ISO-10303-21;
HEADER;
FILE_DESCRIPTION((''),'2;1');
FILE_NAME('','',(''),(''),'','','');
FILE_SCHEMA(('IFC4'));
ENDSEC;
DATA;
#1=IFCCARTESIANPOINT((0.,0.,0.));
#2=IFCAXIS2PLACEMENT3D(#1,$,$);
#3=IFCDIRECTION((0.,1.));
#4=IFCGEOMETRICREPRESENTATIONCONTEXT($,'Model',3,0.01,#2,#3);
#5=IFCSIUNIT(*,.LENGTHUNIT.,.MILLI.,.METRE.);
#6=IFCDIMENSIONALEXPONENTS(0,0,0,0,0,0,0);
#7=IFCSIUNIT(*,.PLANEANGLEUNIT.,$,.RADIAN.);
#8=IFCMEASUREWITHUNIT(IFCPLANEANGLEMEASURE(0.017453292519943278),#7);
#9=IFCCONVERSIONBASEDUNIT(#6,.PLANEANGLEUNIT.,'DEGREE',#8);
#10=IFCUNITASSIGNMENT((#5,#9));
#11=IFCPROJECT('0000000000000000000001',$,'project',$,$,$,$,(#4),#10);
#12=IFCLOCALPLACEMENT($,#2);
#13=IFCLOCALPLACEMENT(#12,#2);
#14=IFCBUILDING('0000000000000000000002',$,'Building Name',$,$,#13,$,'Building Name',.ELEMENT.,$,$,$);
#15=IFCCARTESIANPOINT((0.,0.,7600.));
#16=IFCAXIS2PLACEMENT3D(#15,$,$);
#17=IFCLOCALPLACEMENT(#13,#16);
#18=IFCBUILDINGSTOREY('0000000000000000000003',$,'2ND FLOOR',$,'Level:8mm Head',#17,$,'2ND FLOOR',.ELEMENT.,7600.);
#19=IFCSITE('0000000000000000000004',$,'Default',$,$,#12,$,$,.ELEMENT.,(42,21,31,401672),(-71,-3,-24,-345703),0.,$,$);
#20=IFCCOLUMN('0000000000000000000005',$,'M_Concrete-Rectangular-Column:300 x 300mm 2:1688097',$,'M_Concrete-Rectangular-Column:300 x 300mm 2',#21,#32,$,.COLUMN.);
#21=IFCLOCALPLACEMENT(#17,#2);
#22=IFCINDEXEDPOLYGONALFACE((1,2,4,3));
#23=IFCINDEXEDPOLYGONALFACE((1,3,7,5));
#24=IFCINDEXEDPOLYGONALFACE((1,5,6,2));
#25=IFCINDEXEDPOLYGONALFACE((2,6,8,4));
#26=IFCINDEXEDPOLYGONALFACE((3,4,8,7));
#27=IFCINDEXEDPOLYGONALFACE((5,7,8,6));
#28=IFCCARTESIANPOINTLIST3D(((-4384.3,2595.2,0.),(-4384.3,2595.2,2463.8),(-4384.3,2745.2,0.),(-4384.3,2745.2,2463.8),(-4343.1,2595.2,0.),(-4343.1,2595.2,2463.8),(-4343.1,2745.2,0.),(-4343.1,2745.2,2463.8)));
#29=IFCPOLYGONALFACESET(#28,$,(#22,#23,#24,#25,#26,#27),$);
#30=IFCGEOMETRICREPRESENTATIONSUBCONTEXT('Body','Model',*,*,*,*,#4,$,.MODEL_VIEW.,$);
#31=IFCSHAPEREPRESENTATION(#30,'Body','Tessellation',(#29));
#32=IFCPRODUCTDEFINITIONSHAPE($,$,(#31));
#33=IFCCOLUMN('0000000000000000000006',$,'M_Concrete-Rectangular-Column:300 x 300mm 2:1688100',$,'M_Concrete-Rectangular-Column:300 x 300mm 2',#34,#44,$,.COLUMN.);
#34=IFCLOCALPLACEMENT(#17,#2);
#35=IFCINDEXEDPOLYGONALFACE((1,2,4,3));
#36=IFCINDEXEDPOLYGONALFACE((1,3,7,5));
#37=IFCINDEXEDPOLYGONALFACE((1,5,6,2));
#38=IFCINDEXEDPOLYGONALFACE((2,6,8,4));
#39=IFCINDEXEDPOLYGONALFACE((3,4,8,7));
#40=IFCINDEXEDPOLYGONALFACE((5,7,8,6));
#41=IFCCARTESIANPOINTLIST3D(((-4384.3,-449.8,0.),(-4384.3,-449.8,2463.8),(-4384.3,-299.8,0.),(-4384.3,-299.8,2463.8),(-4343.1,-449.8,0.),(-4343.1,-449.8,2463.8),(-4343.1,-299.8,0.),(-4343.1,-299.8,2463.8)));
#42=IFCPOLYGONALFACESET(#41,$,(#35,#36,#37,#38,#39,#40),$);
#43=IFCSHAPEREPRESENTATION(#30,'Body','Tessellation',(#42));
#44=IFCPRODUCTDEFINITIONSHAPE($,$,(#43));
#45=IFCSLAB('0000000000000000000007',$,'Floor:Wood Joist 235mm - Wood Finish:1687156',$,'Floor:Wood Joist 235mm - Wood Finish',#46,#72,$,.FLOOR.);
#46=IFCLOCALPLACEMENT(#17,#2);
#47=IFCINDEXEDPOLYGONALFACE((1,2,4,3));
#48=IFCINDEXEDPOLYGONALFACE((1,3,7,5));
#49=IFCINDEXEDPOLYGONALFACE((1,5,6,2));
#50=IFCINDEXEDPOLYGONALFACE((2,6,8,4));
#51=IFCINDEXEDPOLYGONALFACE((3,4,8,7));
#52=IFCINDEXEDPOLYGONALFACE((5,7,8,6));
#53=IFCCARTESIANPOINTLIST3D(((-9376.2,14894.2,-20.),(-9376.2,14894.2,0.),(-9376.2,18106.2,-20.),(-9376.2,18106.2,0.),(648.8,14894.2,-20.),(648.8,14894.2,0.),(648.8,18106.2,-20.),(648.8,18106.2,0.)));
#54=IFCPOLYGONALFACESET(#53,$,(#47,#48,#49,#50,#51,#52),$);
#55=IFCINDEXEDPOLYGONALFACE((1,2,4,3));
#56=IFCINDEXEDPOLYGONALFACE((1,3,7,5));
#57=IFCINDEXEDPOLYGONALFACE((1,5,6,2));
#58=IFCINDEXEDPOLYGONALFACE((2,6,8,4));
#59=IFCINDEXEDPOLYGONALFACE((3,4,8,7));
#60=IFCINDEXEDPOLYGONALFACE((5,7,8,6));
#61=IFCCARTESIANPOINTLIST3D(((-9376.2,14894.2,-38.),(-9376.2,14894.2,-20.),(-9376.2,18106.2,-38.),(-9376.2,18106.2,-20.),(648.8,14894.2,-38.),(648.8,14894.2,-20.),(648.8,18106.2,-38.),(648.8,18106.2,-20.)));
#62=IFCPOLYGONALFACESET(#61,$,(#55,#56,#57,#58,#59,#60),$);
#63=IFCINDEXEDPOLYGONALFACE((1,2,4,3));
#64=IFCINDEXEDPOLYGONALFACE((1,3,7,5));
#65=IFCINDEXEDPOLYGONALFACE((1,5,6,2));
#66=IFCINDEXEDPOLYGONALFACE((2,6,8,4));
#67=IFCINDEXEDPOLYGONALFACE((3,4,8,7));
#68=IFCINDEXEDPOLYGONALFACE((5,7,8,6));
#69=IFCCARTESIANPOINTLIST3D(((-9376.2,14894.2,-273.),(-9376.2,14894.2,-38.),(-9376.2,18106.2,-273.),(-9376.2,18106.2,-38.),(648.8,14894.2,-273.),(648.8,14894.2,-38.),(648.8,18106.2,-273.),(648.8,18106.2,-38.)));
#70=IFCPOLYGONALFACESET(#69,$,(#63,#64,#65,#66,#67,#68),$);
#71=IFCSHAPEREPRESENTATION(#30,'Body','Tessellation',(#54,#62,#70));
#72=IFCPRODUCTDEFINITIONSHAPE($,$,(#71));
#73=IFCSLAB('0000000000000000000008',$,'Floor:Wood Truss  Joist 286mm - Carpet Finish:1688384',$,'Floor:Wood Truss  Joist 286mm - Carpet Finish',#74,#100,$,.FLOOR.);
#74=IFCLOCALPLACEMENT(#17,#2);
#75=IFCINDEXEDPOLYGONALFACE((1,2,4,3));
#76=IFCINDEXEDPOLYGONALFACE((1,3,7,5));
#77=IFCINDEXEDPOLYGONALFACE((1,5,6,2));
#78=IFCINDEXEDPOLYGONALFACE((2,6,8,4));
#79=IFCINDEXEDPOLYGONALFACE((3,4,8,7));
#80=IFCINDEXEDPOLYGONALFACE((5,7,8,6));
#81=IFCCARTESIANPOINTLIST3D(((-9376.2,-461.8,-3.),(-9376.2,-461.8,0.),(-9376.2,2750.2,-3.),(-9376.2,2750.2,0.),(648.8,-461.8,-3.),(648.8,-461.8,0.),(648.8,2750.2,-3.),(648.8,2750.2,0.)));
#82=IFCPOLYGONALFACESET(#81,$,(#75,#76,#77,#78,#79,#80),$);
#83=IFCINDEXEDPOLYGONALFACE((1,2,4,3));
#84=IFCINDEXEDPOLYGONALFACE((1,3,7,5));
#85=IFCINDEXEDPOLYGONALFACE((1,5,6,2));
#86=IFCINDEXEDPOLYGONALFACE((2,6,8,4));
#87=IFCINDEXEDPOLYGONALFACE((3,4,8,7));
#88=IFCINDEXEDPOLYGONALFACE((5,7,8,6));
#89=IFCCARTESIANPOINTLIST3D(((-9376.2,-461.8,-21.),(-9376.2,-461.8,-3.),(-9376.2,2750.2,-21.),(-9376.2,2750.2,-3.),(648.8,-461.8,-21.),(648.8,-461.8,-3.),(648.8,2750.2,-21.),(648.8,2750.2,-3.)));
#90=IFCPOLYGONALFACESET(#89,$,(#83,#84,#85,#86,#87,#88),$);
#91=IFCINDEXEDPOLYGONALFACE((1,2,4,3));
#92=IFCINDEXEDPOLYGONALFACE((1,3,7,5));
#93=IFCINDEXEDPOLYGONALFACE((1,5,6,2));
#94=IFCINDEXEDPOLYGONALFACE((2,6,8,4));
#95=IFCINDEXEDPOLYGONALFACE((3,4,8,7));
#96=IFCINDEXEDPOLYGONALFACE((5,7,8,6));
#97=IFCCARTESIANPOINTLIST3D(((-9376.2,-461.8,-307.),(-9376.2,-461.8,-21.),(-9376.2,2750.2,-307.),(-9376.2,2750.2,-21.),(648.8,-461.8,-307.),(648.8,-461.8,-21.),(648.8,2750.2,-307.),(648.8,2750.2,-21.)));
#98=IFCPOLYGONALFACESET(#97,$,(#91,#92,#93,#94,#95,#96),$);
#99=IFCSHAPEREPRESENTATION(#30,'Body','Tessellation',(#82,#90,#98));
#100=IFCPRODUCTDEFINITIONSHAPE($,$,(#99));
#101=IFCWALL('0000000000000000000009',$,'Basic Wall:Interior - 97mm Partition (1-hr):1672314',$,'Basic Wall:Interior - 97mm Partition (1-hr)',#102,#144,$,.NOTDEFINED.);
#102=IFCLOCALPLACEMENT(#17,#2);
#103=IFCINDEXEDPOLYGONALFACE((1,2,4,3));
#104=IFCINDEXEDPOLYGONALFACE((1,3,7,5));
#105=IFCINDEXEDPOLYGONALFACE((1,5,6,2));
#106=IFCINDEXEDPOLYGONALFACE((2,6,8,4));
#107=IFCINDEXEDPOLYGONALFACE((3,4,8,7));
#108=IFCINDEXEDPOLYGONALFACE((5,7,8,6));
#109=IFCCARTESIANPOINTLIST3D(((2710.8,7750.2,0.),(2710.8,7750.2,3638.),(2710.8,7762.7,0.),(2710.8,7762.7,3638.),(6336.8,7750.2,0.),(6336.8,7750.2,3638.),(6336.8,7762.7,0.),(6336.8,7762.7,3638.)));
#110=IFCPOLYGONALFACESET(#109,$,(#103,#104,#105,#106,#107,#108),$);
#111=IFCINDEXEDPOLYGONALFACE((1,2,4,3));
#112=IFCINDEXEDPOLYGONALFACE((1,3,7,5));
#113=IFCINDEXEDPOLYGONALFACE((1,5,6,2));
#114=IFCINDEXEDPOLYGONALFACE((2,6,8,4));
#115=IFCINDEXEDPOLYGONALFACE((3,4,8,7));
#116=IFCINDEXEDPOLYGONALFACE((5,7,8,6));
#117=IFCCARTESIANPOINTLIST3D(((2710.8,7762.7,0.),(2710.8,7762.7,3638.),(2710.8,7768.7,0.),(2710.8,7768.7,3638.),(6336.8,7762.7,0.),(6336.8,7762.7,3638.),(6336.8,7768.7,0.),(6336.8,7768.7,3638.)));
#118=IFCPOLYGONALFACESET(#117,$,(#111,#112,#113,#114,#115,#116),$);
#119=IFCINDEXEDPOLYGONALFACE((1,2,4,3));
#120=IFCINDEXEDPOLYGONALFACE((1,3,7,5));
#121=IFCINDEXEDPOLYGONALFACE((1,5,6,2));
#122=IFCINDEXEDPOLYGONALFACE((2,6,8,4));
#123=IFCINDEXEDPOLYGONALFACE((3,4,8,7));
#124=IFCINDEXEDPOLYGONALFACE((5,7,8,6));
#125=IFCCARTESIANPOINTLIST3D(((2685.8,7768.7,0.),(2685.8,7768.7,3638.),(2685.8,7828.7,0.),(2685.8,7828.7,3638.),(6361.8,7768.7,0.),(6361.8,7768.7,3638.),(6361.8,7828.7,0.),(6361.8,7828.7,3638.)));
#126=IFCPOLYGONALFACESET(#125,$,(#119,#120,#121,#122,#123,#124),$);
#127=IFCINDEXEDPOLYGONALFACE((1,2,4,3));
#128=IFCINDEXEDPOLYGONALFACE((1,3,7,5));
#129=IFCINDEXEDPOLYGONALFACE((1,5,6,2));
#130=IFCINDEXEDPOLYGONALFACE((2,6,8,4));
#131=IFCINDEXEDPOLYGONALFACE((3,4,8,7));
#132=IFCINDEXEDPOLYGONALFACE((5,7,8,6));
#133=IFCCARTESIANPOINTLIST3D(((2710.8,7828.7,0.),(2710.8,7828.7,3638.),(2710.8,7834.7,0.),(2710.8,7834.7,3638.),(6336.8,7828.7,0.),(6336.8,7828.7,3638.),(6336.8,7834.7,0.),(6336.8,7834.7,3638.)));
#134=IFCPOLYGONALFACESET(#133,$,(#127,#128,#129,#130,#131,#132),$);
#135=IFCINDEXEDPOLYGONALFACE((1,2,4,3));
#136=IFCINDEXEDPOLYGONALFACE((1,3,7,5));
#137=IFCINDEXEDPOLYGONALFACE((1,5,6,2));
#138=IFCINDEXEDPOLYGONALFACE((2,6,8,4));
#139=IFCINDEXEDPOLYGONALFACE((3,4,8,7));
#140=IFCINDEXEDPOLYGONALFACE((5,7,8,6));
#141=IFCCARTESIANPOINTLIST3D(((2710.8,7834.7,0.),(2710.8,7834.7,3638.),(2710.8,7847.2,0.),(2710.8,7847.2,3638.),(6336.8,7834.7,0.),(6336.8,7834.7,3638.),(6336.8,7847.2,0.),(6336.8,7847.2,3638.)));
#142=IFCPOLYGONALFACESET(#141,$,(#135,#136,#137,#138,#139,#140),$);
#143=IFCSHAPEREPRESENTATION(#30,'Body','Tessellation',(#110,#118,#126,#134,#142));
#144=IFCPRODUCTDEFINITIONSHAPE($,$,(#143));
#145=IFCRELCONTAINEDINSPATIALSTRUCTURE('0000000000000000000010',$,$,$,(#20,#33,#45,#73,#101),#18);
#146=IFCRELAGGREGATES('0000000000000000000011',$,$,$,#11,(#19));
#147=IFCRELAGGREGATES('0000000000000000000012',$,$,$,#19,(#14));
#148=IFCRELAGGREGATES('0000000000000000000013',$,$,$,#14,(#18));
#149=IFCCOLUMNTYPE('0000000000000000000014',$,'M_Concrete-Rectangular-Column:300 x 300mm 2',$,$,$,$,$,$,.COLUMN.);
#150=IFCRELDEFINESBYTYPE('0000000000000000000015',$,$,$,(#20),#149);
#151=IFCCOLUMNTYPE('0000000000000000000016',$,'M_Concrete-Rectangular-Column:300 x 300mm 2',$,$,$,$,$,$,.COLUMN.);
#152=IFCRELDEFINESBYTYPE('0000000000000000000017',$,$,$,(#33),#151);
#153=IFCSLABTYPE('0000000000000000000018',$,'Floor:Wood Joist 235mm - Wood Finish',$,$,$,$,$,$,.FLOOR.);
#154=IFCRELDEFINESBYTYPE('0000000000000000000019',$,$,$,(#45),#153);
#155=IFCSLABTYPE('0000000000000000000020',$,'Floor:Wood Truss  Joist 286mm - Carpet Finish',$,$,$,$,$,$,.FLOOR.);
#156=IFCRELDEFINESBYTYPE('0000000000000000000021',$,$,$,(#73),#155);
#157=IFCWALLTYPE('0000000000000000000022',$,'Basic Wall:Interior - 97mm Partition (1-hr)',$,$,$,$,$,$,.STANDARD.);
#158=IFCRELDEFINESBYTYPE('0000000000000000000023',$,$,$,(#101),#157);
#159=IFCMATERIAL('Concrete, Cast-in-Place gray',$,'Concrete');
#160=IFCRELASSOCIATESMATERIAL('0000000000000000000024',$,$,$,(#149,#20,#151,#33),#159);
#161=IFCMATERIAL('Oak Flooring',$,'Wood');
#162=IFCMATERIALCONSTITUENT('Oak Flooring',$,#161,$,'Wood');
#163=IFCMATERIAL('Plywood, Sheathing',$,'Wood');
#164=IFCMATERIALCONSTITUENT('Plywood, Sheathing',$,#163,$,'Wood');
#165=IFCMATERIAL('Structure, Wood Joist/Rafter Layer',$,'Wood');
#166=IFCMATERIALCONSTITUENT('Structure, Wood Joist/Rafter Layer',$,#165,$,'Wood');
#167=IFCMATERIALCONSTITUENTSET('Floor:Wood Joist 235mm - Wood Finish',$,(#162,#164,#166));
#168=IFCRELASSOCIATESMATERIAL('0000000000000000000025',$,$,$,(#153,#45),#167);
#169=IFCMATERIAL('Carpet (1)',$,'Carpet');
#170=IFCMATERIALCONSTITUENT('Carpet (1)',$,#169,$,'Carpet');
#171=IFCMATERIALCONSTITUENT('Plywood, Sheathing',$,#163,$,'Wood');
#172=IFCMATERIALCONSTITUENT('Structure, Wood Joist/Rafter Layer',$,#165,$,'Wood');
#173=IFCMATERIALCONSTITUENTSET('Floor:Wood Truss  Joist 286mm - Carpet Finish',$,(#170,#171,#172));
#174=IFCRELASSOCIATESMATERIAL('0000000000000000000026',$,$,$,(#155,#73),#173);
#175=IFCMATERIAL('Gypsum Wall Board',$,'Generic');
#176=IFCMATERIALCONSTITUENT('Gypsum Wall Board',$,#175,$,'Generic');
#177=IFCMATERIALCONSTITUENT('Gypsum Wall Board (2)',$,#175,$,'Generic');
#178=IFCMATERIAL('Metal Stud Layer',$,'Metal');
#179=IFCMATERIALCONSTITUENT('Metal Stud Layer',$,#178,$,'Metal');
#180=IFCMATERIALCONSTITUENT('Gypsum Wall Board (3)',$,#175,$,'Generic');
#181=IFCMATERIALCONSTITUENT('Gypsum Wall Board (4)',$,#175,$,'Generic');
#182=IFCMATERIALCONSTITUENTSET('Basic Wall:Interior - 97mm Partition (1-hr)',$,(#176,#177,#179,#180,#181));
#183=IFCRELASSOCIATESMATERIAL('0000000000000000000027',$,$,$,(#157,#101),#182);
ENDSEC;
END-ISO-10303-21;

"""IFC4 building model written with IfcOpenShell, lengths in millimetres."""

from ifc_helpers import new_model, entity, si_unit, converted_unit, direction, frame, origin, place, context, subcontext, project, spatial, indexed_curve, outline, extrude, source, transform, mapped, material, constituent, constituent_set, type_object, type_shapes, element, save


model = new_model("IFC4")

# Units and contexts
model_context = context("Model", 3, precision=0.01, world=origin(), true_north=direction((0.0, 1.0)))
body_context = subcontext(model_context, "Body", "Model", "MODEL_VIEW")
ifc_project = project(units=[si_unit("LENGTHUNIT", "METRE", prefix="MILLI"), converted_unit("PLANEANGLEUNIT", "DEGREE", entity("IfcPlaneAngleMeasure", 0.017453292519943278), si_unit("PLANEANGLEUNIT", "RADIAN"), dimensions=[0, 0, 0, 0, 0, 0, 0])], contexts=[model_context])

# Site, building, storey
site_placement = place(None, origin())
site = spatial("IfcSite", under=ifc_project, at=site_placement, Name="Default", CompositionType="ELEMENT", RefLatitude=(42, 21, 31, 401672), RefLongitude=(-71, -3, -24, -345703), RefElevation=0.0)
building_placement = place(site_placement, origin())
building = spatial("IfcBuilding", under=site, at=building_placement, Name="Building Name", LongName="Building Name", CompositionType="ELEMENT")
storey_placement = place(building_placement, frame((0.0, 0.0, 7600.0)))
storey = spatial("IfcBuildingStorey", under=building, at=storey_placement, Name="2ND FLOOR", ObjectType="Level:8mm Head", LongName="2ND FLOOR", CompositionType="ELEMENT", Elevation=7600.0)

# Columns
ifc_material_1 = material(Name="Concrete, Cast-in-Place gray", Category="Concrete")
column_type_1 = type_object("IfcColumnType", Name="M_Concrete-Rectangular-Column:300 x 300mm 2", PredefinedType="COLUMN", material=ifc_material_1)
shared_shape_1 = source(origin(), body_context, "Body", "SweptSolid", [
    extrude(outline(indexed_curve([(-1231.9, -75.0), (1231.9, -75.0), (1231.9, 75.0), (-1231.9, 75.0), (-1231.9, -75.0)], self_intersect=False)), frame((-4384.3, 2670.2, 8831.9), z_axis=(1.0, 0.0, 0.0), x_axis=(0.0, 0.0, -1.0)), (0.0, 0.0, 1.0), 41.3),
])
type_shapes(column_type_1, [shared_shape_1])
column_1_placement = place(storey_placement, frame((0.0, 0.0, -7600.0)))
element("IfcColumn", 1, at=column_1_placement, inside=storey, type_object=column_type_1, material=ifc_material_1, Name="M_Concrete-Rectangular-Column:300 x 300mm 2:1688097", ObjectType="M_Concrete-Rectangular-Column:300 x 300mm 2", PredefinedType="COLUMN", context=body_context, shape_type="MappedRepresentation", body=[
    mapped(shared_shape_1, transform((0.0, 0.0, 0.0), scale=1.0)),
])
column_type_2 = type_object("IfcColumnType", Name="M_Concrete-Rectangular-Column:300 x 300mm 2", PredefinedType="COLUMN", material=ifc_material_1)
shared_shape_2 = source(origin(), body_context, "Body", "SweptSolid", [
    extrude(outline(indexed_curve([(-1231.9, -75.0), (1231.9, -75.0), (1231.9, 75.0), (-1231.9, 75.0), (-1231.9, -75.0)], self_intersect=False)), frame((-4384.3, -374.8, 8831.9), z_axis=(1.0, 0.0, 0.0), x_axis=(0.0, 0.0, -1.0)), (0.0, 0.0, 1.0), 41.3),
])
type_shapes(column_type_2, [shared_shape_2])
column_2_placement = place(storey_placement, frame((0.0, 0.0, -7600.0)))
element("IfcColumn", 2, at=column_2_placement, inside=storey, type_object=column_type_2, material=ifc_material_1, Name="M_Concrete-Rectangular-Column:300 x 300mm 2:1688100", ObjectType="M_Concrete-Rectangular-Column:300 x 300mm 2", PredefinedType="COLUMN", context=body_context, shape_type="MappedRepresentation", body=[
    mapped(shared_shape_2, transform((0.0, 0.0, 0.0), scale=1.0)),
])

# Slabs
ifc_material_2 = material(Name="Oak Flooring", Category="Wood")
ifc_constituent_1 = constituent(ifc_material_2, Name="Oak Flooring", Category="Wood")
ifc_material_3 = material(Name="Plywood, Sheathing", Category="Wood")
ifc_constituent_2 = constituent(ifc_material_3, Name="Plywood, Sheathing", Category="Wood")
ifc_material_4 = material(Name="Structure, Wood Joist/Rafter Layer", Category="Wood")
ifc_constituent_3 = constituent(ifc_material_4, Name="Structure, Wood Joist/Rafter Layer", Category="Wood")
ifc_constituent_set_1 = constituent_set(constituents=[ifc_constituent_1, ifc_constituent_2, ifc_constituent_3], Name="Floor:Wood Joist 235mm - Wood Finish")
slab_type_1 = type_object("IfcSlabType", Name="Floor:Wood Joist 235mm - Wood Finish", PredefinedType="FLOOR", material=ifc_constituent_set_1)
slab_1_placement = place(storey_placement, origin())
element("IfcSlab", 3, at=slab_1_placement, inside=storey, type_object=slab_type_1, material=ifc_constituent_set_1, Name="Floor:Wood Joist 235mm - Wood Finish:1687156", ObjectType="Floor:Wood Joist 235mm - Wood Finish", PredefinedType="FLOOR", context=body_context, shape_type="SweptSolid", body=[
    extrude(outline(indexed_curve([(-5012.5, -1606.0), (5012.5, -1606.0), (5012.5, 1606.0), (-5012.5, 1606.0), (-5012.5, -1606.0)], self_intersect=False)), frame((-4363.7, 16500.2, -20.0), z_axis=(0.0, 0.0, 1.0), x_axis=(-1.0, 0.0, 0.0)), (0.0, 0.0, 1.0), 20.0),
    extrude(outline(indexed_curve([(-5012.5, -1606.0), (5012.5, -1606.0), (5012.5, 1606.0), (-5012.5, 1606.0), (-5012.5, -1606.0)], self_intersect=False)), frame((-4363.7, 16500.2, -38.0), z_axis=(0.0, 0.0, 1.0), x_axis=(-1.0, 0.0, 0.0)), (0.0, 0.0, 1.0), 18.0),
    extrude(outline(indexed_curve([(-5012.5, -1606.0), (5012.5, -1606.0), (5012.5, 1606.0), (-5012.5, 1606.0), (-5012.5, -1606.0)], self_intersect=False)), frame((-4363.7, 16500.2, -273.0), z_axis=(0.0, 0.0, 1.0), x_axis=(-1.0, 0.0, 0.0)), (0.0, 0.0, 1.0), 235.0),
])
ifc_material_5 = material(Name="Carpet (1)", Category="Carpet")
ifc_constituent_4 = constituent(ifc_material_5, Name="Carpet (1)", Category="Carpet")
ifc_constituent_5 = constituent(ifc_material_3, Name="Plywood, Sheathing", Category="Wood")
ifc_constituent_6 = constituent(ifc_material_4, Name="Structure, Wood Joist/Rafter Layer", Category="Wood")
ifc_constituent_set_2 = constituent_set(constituents=[ifc_constituent_4, ifc_constituent_5, ifc_constituent_6], Name="Floor:Wood Truss  Joist 286mm - Carpet Finish")
slab_type_2 = type_object("IfcSlabType", Name="Floor:Wood Truss  Joist 286mm - Carpet Finish", PredefinedType="FLOOR", material=ifc_constituent_set_2)
slab_2_placement = place(storey_placement, origin())
element("IfcSlab", 4, at=slab_2_placement, inside=storey, type_object=slab_type_2, material=ifc_constituent_set_2, Name="Floor:Wood Truss  Joist 286mm - Carpet Finish:1688384", ObjectType="Floor:Wood Truss  Joist 286mm - Carpet Finish", PredefinedType="FLOOR", context=body_context, shape_type="SweptSolid", body=[
    extrude(outline(indexed_curve([(-5012.5, -1606.0), (5012.5, -1606.0), (5012.5, 1606.0), (-5012.5, 1606.0), (-5012.5, -1606.0)], self_intersect=False)), frame((-4363.7, 1144.2, -3.0), z_axis=(0.0, 0.0, 1.0), x_axis=(-1.0, 0.0, 0.0)), (0.0, 0.0, 1.0), 3.0),
    extrude(outline(indexed_curve([(-5012.5, -1606.0), (5012.5, -1606.0), (5012.5, 1606.0), (-5012.5, 1606.0), (-5012.5, -1606.0)], self_intersect=False)), frame((-4363.7, 1144.2, -21.0), z_axis=(0.0, 0.0, 1.0), x_axis=(-1.0, 0.0, 0.0)), (0.0, 0.0, 1.0), 18.0),
    extrude(outline(indexed_curve([(-5012.5, -1606.0), (5012.5, -1606.0), (5012.5, 1606.0), (-5012.5, 1606.0), (-5012.5, -1606.0)], self_intersect=False)), frame((-4363.7, 1144.2, -307.0), z_axis=(0.0, 0.0, 1.0), x_axis=(-1.0, 0.0, 0.0)), (0.0, 0.0, 1.0), 286.0),
])

# Wall
ifc_material_6 = material(Name="Gypsum Wall Board", Category="Generic")
ifc_constituent_7 = constituent(ifc_material_6, Name="Gypsum Wall Board", Category="Generic")
ifc_constituent_8 = constituent(ifc_material_6, Name="Gypsum Wall Board (2)", Category="Generic")
ifc_material_7 = material(Name="Metal Stud Layer", Category="Metal")
ifc_constituent_9 = constituent(ifc_material_7, Name="Metal Stud Layer", Category="Metal")
ifc_constituent_10 = constituent(ifc_material_6, Name="Gypsum Wall Board (3)", Category="Generic")
ifc_constituent_11 = constituent(ifc_material_6, Name="Gypsum Wall Board (4)", Category="Generic")
ifc_constituent_set_3 = constituent_set(constituents=[ifc_constituent_7, ifc_constituent_8, ifc_constituent_9, ifc_constituent_10, ifc_constituent_11], Name="Basic Wall:Interior - 97mm Partition (1-hr)")
wall_type = type_object("IfcWallType", Name="Basic Wall:Interior - 97mm Partition (1-hr)", PredefinedType="STANDARD", material=ifc_constituent_set_3)
wall_1_placement = place(storey_placement, frame((6336.8, 7798.7, 0.0), z_axis=(0.0, 0.0, 1.0), x_axis=(-1.0, 0.0, 0.0)))
element("IfcWall", 5, at=wall_1_placement, inside=storey, type_object=wall_type, material=ifc_constituent_set_3, Name="Basic Wall:Interior - 97mm Partition (1-hr):1672314", ObjectType="Basic Wall:Interior - 97mm Partition (1-hr)", PredefinedType="NOTDEFINED", context=body_context, shape_type="SweptSolid", body=[
    extrude(outline(indexed_curve([(-6.2, -1813.0), (6.3, -1813.0), (6.2, 1813.0), (-6.2, 1813.0), (-6.2, -1813.0)], self_intersect=False)), frame((1813.0, 42.3, 0.0), z_axis=(0.0, 0.0, 1.0), x_axis=(0.0, -1.0, 0.0)), (0.0, 0.0, 1.0), 3638.0),
    extrude(outline(indexed_curve([(-1813.0, -3.0), (1813.0, -3.0), (1813.0, 3.0), (-1813.0, 3.0), (-1813.0, -3.0)], self_intersect=False)), frame((1813.0, 33.0, 0.0)), (0.0, 0.0, 1.0), 3638.0),
    extrude(outline(indexed_curve([(-1838.0, -30.0), (1838.0, -30.0), (1838.0, 30.0), (-1838.0, 30.0), (-1838.0, -30.0)], self_intersect=False)), frame((1813.0, 0.0, 0.0)), (0.0, 0.0, 1.0), 3638.0),
    extrude(outline(indexed_curve([(-1813.0, -3.0), (1813.0, -3.0), (1813.0, 3.0), (-1813.0, 3.0), (-1813.0, -3.0)], self_intersect=False)), frame((1813.0, -33.0, 0.0)), (0.0, 0.0, 1.0), 3638.0),
    extrude(outline(indexed_curve([(-6.2, -1813.0), (6.2, -1813.0), (6.2, 1813.0), (-6.3, 1813.0), (-6.2, -1813.0)], self_intersect=False)), frame((1813.0, -42.2, 0.0), z_axis=(0.0, 0.0, 1.0), x_axis=(0.0, 1.0, 0.0)), (0.0, 0.0, 1.0), 3638.0),
])

save(model, "model.ifc")
